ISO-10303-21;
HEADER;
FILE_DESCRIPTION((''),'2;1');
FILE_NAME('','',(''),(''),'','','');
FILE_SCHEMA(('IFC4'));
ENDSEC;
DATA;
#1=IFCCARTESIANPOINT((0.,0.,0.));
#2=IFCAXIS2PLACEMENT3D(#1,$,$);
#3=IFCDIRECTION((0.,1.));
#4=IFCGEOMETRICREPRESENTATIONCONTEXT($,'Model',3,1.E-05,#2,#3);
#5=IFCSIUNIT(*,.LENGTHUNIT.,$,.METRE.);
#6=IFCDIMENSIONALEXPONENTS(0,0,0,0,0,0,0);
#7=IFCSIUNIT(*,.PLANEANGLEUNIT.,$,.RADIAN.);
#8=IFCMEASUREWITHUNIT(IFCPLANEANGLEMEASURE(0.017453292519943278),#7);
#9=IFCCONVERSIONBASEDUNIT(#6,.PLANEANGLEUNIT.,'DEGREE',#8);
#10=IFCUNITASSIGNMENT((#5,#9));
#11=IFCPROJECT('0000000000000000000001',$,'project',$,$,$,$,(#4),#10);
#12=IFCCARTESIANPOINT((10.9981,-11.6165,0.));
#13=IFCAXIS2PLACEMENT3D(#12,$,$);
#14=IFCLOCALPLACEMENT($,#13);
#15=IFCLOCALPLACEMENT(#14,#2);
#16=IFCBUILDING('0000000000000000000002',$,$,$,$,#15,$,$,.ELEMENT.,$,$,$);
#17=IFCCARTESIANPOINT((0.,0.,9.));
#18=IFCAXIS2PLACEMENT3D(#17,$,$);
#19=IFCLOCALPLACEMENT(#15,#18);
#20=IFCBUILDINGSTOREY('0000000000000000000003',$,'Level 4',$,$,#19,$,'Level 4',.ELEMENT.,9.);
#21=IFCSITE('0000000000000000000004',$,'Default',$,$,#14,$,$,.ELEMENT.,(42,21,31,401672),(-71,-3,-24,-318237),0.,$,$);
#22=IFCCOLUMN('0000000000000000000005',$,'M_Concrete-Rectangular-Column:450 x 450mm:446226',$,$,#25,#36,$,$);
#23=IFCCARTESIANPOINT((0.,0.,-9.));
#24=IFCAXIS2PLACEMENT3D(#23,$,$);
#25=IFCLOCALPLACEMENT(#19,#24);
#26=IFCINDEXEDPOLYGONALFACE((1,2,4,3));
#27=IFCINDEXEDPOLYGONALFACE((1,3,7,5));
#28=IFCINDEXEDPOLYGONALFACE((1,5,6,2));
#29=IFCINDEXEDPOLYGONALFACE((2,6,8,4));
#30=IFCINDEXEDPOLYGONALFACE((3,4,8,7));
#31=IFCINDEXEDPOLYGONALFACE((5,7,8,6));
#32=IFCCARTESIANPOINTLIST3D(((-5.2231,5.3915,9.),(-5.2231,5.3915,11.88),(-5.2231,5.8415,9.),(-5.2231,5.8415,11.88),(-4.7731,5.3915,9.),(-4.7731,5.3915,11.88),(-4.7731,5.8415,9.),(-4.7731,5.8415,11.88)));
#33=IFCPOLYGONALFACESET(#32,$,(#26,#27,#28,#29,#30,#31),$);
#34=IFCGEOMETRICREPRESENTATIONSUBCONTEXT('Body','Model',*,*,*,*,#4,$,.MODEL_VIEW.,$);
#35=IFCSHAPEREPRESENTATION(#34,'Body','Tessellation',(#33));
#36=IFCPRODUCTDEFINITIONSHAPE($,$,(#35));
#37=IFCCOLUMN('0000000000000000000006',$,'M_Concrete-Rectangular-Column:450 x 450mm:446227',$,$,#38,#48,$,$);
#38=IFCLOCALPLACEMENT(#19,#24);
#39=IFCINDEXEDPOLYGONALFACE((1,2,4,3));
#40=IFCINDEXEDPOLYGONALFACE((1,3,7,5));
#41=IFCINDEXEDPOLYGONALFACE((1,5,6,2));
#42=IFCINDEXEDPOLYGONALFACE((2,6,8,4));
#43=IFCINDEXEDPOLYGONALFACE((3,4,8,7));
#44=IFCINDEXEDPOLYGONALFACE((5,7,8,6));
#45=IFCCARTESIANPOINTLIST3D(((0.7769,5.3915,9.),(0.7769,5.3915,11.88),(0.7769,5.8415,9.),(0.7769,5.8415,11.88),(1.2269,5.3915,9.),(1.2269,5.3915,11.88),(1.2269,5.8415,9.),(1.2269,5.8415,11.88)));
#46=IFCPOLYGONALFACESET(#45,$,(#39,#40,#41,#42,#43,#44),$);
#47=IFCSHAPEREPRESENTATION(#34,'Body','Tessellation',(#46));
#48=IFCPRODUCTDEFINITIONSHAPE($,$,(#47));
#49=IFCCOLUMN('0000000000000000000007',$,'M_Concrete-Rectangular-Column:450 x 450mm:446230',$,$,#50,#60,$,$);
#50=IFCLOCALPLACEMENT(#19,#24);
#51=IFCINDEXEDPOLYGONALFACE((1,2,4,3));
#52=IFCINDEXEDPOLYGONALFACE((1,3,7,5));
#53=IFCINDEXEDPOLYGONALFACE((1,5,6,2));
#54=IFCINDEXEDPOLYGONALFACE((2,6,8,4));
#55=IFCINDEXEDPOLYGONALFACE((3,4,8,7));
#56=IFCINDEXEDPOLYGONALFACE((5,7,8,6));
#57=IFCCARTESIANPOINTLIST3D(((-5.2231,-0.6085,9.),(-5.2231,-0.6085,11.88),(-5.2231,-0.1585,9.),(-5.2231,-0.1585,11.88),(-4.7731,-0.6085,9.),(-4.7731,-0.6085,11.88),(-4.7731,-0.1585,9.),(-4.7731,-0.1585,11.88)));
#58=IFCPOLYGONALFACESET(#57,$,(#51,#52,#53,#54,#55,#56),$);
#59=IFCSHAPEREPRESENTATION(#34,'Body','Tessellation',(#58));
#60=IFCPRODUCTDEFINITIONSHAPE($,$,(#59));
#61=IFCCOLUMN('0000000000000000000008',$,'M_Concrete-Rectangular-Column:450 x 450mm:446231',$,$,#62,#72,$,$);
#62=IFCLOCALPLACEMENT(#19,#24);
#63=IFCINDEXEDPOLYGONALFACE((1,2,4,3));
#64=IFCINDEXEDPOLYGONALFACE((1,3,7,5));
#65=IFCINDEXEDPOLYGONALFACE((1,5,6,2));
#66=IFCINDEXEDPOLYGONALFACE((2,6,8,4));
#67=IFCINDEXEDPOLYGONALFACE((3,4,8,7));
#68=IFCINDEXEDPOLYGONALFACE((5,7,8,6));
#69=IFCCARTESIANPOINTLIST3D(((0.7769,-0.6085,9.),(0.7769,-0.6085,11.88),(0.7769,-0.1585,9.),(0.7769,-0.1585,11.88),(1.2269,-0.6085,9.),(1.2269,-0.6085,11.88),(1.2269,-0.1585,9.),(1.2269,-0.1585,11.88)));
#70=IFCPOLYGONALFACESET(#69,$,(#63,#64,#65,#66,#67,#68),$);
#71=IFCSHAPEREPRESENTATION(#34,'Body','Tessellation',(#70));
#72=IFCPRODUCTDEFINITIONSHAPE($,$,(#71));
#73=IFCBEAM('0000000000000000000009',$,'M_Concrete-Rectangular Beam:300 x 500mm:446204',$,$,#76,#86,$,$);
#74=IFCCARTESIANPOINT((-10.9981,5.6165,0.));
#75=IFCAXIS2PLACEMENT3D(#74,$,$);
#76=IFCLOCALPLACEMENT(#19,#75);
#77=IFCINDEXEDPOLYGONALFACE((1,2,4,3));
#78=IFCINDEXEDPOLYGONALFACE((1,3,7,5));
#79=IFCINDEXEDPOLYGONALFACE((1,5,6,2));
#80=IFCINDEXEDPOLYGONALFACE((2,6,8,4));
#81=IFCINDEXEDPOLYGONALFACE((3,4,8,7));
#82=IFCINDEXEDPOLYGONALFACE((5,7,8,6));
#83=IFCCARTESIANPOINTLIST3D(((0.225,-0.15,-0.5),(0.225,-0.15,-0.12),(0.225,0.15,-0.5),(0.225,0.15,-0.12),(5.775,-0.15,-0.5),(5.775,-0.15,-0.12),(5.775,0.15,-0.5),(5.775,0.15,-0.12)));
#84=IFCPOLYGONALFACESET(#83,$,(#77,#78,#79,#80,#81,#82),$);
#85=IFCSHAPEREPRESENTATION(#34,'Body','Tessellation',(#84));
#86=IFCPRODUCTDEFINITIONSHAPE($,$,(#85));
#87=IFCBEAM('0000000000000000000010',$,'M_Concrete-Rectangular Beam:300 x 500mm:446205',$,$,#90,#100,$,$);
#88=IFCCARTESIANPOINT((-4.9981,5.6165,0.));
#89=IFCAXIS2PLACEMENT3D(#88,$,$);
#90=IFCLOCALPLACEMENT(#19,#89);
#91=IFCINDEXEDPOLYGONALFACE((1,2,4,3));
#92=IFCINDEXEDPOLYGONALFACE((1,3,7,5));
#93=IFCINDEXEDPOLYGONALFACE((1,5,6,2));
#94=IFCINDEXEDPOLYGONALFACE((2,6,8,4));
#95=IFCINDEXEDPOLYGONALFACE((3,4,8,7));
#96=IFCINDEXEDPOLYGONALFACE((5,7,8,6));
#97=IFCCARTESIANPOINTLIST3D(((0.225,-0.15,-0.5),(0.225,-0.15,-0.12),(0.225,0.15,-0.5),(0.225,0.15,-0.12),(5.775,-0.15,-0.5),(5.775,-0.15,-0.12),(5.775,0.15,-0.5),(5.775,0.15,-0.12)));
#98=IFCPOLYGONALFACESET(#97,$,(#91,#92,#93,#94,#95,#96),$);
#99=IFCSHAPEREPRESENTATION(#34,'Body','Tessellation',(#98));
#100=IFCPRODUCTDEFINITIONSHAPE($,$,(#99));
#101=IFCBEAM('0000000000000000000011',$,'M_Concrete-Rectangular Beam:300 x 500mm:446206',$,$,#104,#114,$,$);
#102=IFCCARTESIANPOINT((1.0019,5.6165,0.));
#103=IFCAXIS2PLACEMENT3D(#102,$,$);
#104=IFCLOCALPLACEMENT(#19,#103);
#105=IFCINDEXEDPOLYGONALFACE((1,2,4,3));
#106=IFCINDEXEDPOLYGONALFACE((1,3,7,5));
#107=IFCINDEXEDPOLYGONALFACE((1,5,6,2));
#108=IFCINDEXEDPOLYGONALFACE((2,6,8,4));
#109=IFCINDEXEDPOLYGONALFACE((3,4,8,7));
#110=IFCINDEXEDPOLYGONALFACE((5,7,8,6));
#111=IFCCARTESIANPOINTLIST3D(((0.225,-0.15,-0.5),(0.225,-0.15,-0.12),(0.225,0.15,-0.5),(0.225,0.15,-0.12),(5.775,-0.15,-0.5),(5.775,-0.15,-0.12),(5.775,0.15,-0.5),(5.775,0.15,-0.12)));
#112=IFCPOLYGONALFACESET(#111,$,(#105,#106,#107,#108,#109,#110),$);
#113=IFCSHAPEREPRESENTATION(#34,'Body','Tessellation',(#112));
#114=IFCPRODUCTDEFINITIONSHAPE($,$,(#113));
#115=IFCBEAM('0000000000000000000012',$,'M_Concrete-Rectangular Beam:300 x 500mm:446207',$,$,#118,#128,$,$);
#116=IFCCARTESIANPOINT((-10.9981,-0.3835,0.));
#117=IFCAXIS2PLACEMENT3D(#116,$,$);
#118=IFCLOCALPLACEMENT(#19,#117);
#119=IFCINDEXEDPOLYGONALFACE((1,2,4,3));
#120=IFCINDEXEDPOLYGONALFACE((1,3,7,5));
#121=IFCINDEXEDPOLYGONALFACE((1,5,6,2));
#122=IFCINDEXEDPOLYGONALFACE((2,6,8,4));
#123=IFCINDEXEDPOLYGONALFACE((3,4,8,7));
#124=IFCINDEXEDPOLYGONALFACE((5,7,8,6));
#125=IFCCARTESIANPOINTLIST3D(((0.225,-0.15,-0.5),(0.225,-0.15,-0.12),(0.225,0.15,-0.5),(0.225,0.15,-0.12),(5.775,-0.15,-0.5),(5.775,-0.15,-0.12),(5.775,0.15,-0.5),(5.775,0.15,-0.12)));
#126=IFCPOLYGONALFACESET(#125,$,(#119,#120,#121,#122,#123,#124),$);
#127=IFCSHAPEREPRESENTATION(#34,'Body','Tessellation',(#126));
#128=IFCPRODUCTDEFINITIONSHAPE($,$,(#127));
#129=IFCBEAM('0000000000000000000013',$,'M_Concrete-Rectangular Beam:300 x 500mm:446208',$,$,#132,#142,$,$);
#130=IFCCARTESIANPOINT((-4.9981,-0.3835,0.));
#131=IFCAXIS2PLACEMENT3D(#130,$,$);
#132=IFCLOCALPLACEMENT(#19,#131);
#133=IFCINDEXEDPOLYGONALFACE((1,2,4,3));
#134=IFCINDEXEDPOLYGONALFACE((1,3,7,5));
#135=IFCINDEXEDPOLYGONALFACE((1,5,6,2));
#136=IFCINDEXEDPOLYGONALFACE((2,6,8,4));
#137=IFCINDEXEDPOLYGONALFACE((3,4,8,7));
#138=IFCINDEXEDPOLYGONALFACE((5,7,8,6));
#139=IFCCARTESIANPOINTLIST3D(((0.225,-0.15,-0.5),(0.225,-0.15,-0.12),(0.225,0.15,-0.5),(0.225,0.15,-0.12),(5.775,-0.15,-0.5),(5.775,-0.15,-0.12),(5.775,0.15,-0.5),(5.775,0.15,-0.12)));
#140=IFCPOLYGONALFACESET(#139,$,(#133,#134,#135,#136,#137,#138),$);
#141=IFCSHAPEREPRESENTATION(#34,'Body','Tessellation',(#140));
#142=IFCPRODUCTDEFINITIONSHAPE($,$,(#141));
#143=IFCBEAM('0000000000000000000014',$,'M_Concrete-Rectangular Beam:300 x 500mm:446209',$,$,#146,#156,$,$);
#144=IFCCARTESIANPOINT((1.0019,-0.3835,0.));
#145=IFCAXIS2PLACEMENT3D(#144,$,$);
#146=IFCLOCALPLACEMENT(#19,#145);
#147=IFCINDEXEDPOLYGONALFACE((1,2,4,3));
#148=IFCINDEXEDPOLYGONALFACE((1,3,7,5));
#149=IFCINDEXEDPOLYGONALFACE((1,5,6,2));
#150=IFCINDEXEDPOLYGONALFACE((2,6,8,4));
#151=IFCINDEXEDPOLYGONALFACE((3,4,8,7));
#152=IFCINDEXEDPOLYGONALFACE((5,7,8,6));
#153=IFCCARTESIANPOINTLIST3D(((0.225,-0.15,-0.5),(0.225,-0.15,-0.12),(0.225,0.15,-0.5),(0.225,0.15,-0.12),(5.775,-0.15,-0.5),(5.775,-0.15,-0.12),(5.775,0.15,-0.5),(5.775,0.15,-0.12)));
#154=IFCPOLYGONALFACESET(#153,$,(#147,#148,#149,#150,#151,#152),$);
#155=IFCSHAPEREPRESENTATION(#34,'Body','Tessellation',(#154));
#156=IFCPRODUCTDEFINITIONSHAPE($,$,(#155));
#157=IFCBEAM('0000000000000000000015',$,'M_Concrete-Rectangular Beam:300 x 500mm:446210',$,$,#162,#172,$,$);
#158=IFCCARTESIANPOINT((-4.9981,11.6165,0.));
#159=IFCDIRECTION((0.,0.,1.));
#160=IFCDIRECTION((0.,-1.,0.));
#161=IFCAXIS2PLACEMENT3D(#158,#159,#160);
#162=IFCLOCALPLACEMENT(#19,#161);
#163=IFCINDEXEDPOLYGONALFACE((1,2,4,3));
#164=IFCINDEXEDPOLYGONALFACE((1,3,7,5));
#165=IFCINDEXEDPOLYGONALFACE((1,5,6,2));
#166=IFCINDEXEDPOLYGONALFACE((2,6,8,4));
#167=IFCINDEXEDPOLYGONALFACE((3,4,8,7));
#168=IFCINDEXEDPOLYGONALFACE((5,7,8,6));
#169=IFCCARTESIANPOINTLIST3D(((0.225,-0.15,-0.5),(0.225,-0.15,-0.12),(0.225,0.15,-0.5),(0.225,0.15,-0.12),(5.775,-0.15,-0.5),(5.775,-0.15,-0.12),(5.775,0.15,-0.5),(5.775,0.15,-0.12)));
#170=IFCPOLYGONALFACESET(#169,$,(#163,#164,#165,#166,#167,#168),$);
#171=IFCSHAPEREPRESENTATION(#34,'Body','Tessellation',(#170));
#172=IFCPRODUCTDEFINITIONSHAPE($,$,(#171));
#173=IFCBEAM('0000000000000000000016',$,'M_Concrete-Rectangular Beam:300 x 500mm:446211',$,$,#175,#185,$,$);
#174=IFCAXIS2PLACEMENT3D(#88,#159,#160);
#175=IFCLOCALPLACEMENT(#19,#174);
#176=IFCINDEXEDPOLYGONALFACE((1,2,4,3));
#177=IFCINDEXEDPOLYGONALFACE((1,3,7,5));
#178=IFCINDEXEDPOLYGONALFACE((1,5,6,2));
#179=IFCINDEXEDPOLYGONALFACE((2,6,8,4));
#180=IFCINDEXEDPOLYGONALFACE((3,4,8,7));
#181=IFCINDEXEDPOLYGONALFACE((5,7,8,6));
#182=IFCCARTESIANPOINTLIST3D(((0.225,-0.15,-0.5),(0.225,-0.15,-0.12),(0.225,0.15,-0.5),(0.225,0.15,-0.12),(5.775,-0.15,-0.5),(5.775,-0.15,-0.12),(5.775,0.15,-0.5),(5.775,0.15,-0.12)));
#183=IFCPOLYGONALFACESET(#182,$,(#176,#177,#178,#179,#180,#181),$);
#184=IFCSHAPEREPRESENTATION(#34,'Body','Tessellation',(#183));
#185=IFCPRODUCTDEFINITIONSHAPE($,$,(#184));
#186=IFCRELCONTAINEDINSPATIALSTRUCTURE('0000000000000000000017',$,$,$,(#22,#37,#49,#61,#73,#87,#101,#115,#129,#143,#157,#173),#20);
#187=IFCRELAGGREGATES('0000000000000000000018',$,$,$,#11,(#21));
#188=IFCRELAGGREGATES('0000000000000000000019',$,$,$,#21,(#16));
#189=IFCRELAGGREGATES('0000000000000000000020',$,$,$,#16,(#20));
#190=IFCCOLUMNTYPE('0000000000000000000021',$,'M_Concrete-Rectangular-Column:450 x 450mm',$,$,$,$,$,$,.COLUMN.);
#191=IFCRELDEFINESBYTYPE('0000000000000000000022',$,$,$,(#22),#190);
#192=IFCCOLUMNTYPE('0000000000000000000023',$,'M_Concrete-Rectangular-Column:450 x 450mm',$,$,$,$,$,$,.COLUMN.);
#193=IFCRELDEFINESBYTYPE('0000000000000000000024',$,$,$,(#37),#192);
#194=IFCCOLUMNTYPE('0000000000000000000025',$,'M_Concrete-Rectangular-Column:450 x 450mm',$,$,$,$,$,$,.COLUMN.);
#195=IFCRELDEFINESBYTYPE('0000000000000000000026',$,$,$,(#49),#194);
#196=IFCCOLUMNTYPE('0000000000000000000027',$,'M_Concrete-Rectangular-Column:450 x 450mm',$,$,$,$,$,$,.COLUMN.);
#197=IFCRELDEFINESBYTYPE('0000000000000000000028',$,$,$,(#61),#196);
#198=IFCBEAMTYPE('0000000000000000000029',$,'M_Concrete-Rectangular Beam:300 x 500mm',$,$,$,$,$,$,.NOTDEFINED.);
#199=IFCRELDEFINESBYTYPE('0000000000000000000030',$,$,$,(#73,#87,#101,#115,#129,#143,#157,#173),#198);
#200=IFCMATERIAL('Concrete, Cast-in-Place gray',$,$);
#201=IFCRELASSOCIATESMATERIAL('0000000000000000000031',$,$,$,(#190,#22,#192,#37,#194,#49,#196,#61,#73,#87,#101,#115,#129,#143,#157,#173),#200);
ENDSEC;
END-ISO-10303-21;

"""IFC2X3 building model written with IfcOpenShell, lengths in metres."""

from ifc_helpers import new_model, entity, si_unit, converted_unit, direction, frame, frame_2d, origin, place, context, subcontext, project, spatial, rectangle, extrude, source, transform, mapped, material, type_object, type_shapes, element, save


model = new_model("IFC2X3")

# Units and contexts
model_context = context("Model", 3, precision=1e-05, world=origin(), true_north=direction((0.0, 1.0)))
body_context = subcontext(model_context, "Body", "Model", "MODEL_VIEW")
ifc_project = project(units=[si_unit("LENGTHUNIT", "METRE"), converted_unit("PLANEANGLEUNIT", "DEGREE", entity("IfcPlaneAngleMeasure", 0.017453292519943278), si_unit("PLANEANGLEUNIT", "RADIAN"), dimensions=[0, 0, 0, 0, 0, 0, 0])], contexts=[model_context])

# Site, building, storey
site_placement = place(None, frame((10.9981, -11.6165, 0.0)))
site = spatial("IfcSite", under=ifc_project, at=site_placement, Name="Default", CompositionType="ELEMENT", RefLatitude=(42, 21, 31, 401672), RefLongitude=(-71, -3, -24, -318237), RefElevation=0.0)
building_placement = place(site_placement, origin())
building = spatial("IfcBuilding", under=site, at=building_placement, CompositionType="ELEMENT")
storey_placement = place(building_placement, frame((0.0, 0.0, 9.0)))
storey = spatial("IfcBuildingStorey", under=building, at=storey_placement, Name="Level 4", LongName="Level 4", CompositionType="ELEMENT", Elevation=9.0)

# Columns
ifc_material_1 = material(Name="Concrete, Cast-in-Place gray")
column_type_1 = type_object("IfcColumnType", Name="M_Concrete-Rectangular-Column:450 x 450mm", PredefinedType="COLUMN", material=ifc_material_1)
shared_shape_1 = source(origin(), body_context, "Body", "SweptSolid", [
    extrude(rectangle(XDim=0.45, YDim=0.45, at=frame_2d((0.0, 0.0), x_axis=(1.0, 0.0))), frame((-4.9981, 5.6165, 9.0), z_axis=(0.0, 0.0, 1.0), x_axis=(-1.0, 0.0, 0.0)), (0.0, 0.0, 1.0), 2.88),
])
type_shapes(column_type_1, [shared_shape_1])
column_1_placement = place(storey_placement, frame((0.0, 0.0, -9.0)))
element("IfcColumn", 1, at=column_1_placement, inside=storey, type_object=column_type_1, material=ifc_material_1, Name="M_Concrete-Rectangular-Column:450 x 450mm:446226", context=body_context, shape_type="MappedRepresentation", body=[
    mapped(shared_shape_1, transform((0.0, 0.0, 0.0), scale=1.0)),
])
column_type_2 = type_object("IfcColumnType", Name="M_Concrete-Rectangular-Column:450 x 450mm", PredefinedType="COLUMN", material=ifc_material_1)
shared_shape_2 = source(origin(), body_context, "Body", "SweptSolid", [
    extrude(rectangle(XDim=0.45, YDim=0.45, at=frame_2d((0.0, 0.0), x_axis=(1.0, 0.0))), frame((1.0019, 5.6165, 9.0), z_axis=(0.0, 0.0, 1.0), x_axis=(-1.0, 0.0, 0.0)), (0.0, 0.0, 1.0), 2.88),
])
type_shapes(column_type_2, [shared_shape_2])
column_2_placement = place(storey_placement, frame((0.0, 0.0, -9.0)))
element("IfcColumn", 2, at=column_2_placement, inside=storey, type_object=column_type_2, material=ifc_material_1, Name="M_Concrete-Rectangular-Column:450 x 450mm:446227", context=body_context, shape_type="MappedRepresentation", body=[
    mapped(shared_shape_2, transform((0.0, 0.0, 0.0), scale=1.0)),
])
column_type_3 = type_object("IfcColumnType", Name="M_Concrete-Rectangular-Column:450 x 450mm", PredefinedType="COLUMN", material=ifc_material_1)
shared_shape_3 = source(origin(), body_context, "Body", "SweptSolid", [
    extrude(rectangle(XDim=0.45, YDim=0.45, at=frame_2d((0.0, 0.0), x_axis=(1.0, 0.0))), frame((-4.9981, -0.3835, 9.0), z_axis=(0.0, 0.0, 1.0), x_axis=(-1.0, 0.0, 0.0)), (0.0, 0.0, 1.0), 2.88),
])
type_shapes(column_type_3, [shared_shape_3])
column_3_placement = place(storey_placement, frame((0.0, 0.0, -9.0)))
element("IfcColumn", 3, at=column_3_placement, inside=storey, type_object=column_type_3, material=ifc_material_1, Name="M_Concrete-Rectangular-Column:450 x 450mm:446230", context=body_context, shape_type="MappedRepresentation", body=[
    mapped(shared_shape_3, transform((0.0, 0.0, 0.0), scale=1.0)),
])
column_type_4 = type_object("IfcColumnType", Name="M_Concrete-Rectangular-Column:450 x 450mm", PredefinedType="COLUMN", material=ifc_material_1)
shared_shape_4 = source(origin(), body_context, "Body", "SweptSolid", [
    extrude(rectangle(XDim=0.45, YDim=0.45, at=frame_2d((0.0, 0.0), x_axis=(1.0, 0.0))), frame((1.0019, -0.3835, 9.0), z_axis=(0.0, 0.0, 1.0), x_axis=(-1.0, 0.0, 0.0)), (0.0, 0.0, 1.0), 2.88),
])
type_shapes(column_type_4, [shared_shape_4])
column_4_placement = place(storey_placement, frame((0.0, 0.0, -9.0)))
element("IfcColumn", 4, at=column_4_placement, inside=storey, type_object=column_type_4, material=ifc_material_1, Name="M_Concrete-Rectangular-Column:450 x 450mm:446231", context=body_context, shape_type="MappedRepresentation", body=[
    mapped(shared_shape_4, transform((0.0, 0.0, 0.0), scale=1.0)),
])

# Beams
beam_type = type_object("IfcBeamType", Name="M_Concrete-Rectangular Beam:300 x 500mm", PredefinedType="NOTDEFINED")
beam_1_placement = place(storey_placement, frame((-10.9981, 5.6165, 0.0)))
element("IfcBeam", 5, at=beam_1_placement, inside=storey, type_object=beam_type, material=ifc_material_1, Name="M_Concrete-Rectangular Beam:300 x 500mm:446204", context=body_context, shape_type="SweptSolid", body=[
    extrude(rectangle(XDim=0.38, YDim=0.3, at=frame_2d((0.0, 0.0), x_axis=(1.0, 0.0))), frame((0.225, 0.0, -0.31), z_axis=(1.0, 0.0, 0.0), x_axis=(0.0, 0.0, -1.0)), (0.0, 0.0, 1.0), 5.55),
])
beam_2_placement = place(storey_placement, frame((-4.9981, 5.6165, 0.0)))
element("IfcBeam", 6, at=beam_2_placement, inside=storey, type_object=beam_type, material=ifc_material_1, Name="M_Concrete-Rectangular Beam:300 x 500mm:446205", context=body_context, shape_type="SweptSolid", body=[
    extrude(rectangle(XDim=0.38, YDim=0.3, at=frame_2d((0.0, 0.0), x_axis=(1.0, 0.0))), frame((0.225, 0.0, -0.31), z_axis=(1.0, 0.0, 0.0), x_axis=(0.0, 0.0, -1.0)), (0.0, 0.0, 1.0), 5.55),
])
beam_3_placement = place(storey_placement, frame((1.0019, 5.6165, 0.0)))
element("IfcBeam", 7, at=beam_3_placement, inside=storey, type_object=beam_type, material=ifc_material_1, Name="M_Concrete-Rectangular Beam:300 x 500mm:446206", context=body_context, shape_type="SweptSolid", body=[
    extrude(rectangle(XDim=0.38, YDim=0.3, at=frame_2d((0.0, 0.0), x_axis=(1.0, 0.0))), frame((0.225, 0.0, -0.31), z_axis=(1.0, 0.0, 0.0), x_axis=(0.0, 0.0, -1.0)), (0.0, 0.0, 1.0), 5.55),
])
beam_4_placement = place(storey_placement, frame((-10.9981, -0.3835, 0.0)))
element("IfcBeam", 8, at=beam_4_placement, inside=storey, type_object=beam_type, material=ifc_material_1, Name="M_Concrete-Rectangular Beam:300 x 500mm:446207", context=body_context, shape_type="SweptSolid", body=[
    extrude(rectangle(XDim=0.38, YDim=0.3, at=frame_2d((0.0, 0.0), x_axis=(1.0, 0.0))), frame((0.225, 0.0, -0.31), z_axis=(1.0, 0.0, 0.0), x_axis=(0.0, 0.0, -1.0)), (0.0, 0.0, 1.0), 5.55),
])
beam_5_placement = place(storey_placement, frame((-4.9981, -0.3835, 0.0)))
element("IfcBeam", 9, at=beam_5_placement, inside=storey, type_object=beam_type, material=ifc_material_1, Name="M_Concrete-Rectangular Beam:300 x 500mm:446208", context=body_context, shape_type="SweptSolid", body=[
    extrude(rectangle(XDim=0.38, YDim=0.3, at=frame_2d((0.0, 0.0), x_axis=(1.0, 0.0))), frame((0.225, 0.0, -0.31), z_axis=(1.0, 0.0, 0.0), x_axis=(0.0, 0.0, -1.0)), (0.0, 0.0, 1.0), 5.55),
])
beam_6_placement = place(storey_placement, frame((1.0019, -0.3835, 0.0)))
element("IfcBeam", 10, at=beam_6_placement, inside=storey, type_object=beam_type, material=ifc_material_1, Name="M_Concrete-Rectangular Beam:300 x 500mm:446209", context=body_context, shape_type="SweptSolid", body=[
    extrude(rectangle(XDim=0.38, YDim=0.3, at=frame_2d((0.0, 0.0), x_axis=(1.0, 0.0))), frame((0.225, 0.0, -0.31), z_axis=(1.0, 0.0, 0.0), x_axis=(0.0, 0.0, -1.0)), (0.0, 0.0, 1.0), 5.55),
])
beam_7_placement = place(storey_placement, frame((-4.9981, 11.6165, 0.0), z_axis=(0.0, 0.0, 1.0), x_axis=(0.0, -1.0, 0.0)))
element("IfcBeam", 11, at=beam_7_placement, inside=storey, type_object=beam_type, material=ifc_material_1, Name="M_Concrete-Rectangular Beam:300 x 500mm:446210", context=body_context, shape_type="SweptSolid", body=[
    extrude(rectangle(XDim=0.38, YDim=0.3, at=frame_2d((0.0, 0.0), x_axis=(1.0, 0.0))), frame((0.225, 0.0, -0.31), z_axis=(1.0, 0.0, 0.0), x_axis=(0.0, 0.0, -1.0)), (0.0, 0.0, 1.0), 5.55),
])
beam_8_placement = place(storey_placement, frame((-4.9981, 5.6165, 0.0), z_axis=(0.0, 0.0, 1.0), x_axis=(0.0, -1.0, 0.0)))
element("IfcBeam", 12, at=beam_8_placement, inside=storey, type_object=beam_type, material=ifc_material_1, Name="M_Concrete-Rectangular Beam:300 x 500mm:446211", context=body_context, shape_type="SweptSolid", body=[
    extrude(rectangle(XDim=0.38, YDim=0.3, at=frame_2d((0.0, 0.0), x_axis=(1.0, 0.0))), frame((0.225, 0.0, -0.31), z_axis=(1.0, 0.0, 0.0), x_axis=(0.0, 0.0, -1.0)), (0.0, 0.0, 1.0), 5.55),
])

save(model, "model.ifc")
